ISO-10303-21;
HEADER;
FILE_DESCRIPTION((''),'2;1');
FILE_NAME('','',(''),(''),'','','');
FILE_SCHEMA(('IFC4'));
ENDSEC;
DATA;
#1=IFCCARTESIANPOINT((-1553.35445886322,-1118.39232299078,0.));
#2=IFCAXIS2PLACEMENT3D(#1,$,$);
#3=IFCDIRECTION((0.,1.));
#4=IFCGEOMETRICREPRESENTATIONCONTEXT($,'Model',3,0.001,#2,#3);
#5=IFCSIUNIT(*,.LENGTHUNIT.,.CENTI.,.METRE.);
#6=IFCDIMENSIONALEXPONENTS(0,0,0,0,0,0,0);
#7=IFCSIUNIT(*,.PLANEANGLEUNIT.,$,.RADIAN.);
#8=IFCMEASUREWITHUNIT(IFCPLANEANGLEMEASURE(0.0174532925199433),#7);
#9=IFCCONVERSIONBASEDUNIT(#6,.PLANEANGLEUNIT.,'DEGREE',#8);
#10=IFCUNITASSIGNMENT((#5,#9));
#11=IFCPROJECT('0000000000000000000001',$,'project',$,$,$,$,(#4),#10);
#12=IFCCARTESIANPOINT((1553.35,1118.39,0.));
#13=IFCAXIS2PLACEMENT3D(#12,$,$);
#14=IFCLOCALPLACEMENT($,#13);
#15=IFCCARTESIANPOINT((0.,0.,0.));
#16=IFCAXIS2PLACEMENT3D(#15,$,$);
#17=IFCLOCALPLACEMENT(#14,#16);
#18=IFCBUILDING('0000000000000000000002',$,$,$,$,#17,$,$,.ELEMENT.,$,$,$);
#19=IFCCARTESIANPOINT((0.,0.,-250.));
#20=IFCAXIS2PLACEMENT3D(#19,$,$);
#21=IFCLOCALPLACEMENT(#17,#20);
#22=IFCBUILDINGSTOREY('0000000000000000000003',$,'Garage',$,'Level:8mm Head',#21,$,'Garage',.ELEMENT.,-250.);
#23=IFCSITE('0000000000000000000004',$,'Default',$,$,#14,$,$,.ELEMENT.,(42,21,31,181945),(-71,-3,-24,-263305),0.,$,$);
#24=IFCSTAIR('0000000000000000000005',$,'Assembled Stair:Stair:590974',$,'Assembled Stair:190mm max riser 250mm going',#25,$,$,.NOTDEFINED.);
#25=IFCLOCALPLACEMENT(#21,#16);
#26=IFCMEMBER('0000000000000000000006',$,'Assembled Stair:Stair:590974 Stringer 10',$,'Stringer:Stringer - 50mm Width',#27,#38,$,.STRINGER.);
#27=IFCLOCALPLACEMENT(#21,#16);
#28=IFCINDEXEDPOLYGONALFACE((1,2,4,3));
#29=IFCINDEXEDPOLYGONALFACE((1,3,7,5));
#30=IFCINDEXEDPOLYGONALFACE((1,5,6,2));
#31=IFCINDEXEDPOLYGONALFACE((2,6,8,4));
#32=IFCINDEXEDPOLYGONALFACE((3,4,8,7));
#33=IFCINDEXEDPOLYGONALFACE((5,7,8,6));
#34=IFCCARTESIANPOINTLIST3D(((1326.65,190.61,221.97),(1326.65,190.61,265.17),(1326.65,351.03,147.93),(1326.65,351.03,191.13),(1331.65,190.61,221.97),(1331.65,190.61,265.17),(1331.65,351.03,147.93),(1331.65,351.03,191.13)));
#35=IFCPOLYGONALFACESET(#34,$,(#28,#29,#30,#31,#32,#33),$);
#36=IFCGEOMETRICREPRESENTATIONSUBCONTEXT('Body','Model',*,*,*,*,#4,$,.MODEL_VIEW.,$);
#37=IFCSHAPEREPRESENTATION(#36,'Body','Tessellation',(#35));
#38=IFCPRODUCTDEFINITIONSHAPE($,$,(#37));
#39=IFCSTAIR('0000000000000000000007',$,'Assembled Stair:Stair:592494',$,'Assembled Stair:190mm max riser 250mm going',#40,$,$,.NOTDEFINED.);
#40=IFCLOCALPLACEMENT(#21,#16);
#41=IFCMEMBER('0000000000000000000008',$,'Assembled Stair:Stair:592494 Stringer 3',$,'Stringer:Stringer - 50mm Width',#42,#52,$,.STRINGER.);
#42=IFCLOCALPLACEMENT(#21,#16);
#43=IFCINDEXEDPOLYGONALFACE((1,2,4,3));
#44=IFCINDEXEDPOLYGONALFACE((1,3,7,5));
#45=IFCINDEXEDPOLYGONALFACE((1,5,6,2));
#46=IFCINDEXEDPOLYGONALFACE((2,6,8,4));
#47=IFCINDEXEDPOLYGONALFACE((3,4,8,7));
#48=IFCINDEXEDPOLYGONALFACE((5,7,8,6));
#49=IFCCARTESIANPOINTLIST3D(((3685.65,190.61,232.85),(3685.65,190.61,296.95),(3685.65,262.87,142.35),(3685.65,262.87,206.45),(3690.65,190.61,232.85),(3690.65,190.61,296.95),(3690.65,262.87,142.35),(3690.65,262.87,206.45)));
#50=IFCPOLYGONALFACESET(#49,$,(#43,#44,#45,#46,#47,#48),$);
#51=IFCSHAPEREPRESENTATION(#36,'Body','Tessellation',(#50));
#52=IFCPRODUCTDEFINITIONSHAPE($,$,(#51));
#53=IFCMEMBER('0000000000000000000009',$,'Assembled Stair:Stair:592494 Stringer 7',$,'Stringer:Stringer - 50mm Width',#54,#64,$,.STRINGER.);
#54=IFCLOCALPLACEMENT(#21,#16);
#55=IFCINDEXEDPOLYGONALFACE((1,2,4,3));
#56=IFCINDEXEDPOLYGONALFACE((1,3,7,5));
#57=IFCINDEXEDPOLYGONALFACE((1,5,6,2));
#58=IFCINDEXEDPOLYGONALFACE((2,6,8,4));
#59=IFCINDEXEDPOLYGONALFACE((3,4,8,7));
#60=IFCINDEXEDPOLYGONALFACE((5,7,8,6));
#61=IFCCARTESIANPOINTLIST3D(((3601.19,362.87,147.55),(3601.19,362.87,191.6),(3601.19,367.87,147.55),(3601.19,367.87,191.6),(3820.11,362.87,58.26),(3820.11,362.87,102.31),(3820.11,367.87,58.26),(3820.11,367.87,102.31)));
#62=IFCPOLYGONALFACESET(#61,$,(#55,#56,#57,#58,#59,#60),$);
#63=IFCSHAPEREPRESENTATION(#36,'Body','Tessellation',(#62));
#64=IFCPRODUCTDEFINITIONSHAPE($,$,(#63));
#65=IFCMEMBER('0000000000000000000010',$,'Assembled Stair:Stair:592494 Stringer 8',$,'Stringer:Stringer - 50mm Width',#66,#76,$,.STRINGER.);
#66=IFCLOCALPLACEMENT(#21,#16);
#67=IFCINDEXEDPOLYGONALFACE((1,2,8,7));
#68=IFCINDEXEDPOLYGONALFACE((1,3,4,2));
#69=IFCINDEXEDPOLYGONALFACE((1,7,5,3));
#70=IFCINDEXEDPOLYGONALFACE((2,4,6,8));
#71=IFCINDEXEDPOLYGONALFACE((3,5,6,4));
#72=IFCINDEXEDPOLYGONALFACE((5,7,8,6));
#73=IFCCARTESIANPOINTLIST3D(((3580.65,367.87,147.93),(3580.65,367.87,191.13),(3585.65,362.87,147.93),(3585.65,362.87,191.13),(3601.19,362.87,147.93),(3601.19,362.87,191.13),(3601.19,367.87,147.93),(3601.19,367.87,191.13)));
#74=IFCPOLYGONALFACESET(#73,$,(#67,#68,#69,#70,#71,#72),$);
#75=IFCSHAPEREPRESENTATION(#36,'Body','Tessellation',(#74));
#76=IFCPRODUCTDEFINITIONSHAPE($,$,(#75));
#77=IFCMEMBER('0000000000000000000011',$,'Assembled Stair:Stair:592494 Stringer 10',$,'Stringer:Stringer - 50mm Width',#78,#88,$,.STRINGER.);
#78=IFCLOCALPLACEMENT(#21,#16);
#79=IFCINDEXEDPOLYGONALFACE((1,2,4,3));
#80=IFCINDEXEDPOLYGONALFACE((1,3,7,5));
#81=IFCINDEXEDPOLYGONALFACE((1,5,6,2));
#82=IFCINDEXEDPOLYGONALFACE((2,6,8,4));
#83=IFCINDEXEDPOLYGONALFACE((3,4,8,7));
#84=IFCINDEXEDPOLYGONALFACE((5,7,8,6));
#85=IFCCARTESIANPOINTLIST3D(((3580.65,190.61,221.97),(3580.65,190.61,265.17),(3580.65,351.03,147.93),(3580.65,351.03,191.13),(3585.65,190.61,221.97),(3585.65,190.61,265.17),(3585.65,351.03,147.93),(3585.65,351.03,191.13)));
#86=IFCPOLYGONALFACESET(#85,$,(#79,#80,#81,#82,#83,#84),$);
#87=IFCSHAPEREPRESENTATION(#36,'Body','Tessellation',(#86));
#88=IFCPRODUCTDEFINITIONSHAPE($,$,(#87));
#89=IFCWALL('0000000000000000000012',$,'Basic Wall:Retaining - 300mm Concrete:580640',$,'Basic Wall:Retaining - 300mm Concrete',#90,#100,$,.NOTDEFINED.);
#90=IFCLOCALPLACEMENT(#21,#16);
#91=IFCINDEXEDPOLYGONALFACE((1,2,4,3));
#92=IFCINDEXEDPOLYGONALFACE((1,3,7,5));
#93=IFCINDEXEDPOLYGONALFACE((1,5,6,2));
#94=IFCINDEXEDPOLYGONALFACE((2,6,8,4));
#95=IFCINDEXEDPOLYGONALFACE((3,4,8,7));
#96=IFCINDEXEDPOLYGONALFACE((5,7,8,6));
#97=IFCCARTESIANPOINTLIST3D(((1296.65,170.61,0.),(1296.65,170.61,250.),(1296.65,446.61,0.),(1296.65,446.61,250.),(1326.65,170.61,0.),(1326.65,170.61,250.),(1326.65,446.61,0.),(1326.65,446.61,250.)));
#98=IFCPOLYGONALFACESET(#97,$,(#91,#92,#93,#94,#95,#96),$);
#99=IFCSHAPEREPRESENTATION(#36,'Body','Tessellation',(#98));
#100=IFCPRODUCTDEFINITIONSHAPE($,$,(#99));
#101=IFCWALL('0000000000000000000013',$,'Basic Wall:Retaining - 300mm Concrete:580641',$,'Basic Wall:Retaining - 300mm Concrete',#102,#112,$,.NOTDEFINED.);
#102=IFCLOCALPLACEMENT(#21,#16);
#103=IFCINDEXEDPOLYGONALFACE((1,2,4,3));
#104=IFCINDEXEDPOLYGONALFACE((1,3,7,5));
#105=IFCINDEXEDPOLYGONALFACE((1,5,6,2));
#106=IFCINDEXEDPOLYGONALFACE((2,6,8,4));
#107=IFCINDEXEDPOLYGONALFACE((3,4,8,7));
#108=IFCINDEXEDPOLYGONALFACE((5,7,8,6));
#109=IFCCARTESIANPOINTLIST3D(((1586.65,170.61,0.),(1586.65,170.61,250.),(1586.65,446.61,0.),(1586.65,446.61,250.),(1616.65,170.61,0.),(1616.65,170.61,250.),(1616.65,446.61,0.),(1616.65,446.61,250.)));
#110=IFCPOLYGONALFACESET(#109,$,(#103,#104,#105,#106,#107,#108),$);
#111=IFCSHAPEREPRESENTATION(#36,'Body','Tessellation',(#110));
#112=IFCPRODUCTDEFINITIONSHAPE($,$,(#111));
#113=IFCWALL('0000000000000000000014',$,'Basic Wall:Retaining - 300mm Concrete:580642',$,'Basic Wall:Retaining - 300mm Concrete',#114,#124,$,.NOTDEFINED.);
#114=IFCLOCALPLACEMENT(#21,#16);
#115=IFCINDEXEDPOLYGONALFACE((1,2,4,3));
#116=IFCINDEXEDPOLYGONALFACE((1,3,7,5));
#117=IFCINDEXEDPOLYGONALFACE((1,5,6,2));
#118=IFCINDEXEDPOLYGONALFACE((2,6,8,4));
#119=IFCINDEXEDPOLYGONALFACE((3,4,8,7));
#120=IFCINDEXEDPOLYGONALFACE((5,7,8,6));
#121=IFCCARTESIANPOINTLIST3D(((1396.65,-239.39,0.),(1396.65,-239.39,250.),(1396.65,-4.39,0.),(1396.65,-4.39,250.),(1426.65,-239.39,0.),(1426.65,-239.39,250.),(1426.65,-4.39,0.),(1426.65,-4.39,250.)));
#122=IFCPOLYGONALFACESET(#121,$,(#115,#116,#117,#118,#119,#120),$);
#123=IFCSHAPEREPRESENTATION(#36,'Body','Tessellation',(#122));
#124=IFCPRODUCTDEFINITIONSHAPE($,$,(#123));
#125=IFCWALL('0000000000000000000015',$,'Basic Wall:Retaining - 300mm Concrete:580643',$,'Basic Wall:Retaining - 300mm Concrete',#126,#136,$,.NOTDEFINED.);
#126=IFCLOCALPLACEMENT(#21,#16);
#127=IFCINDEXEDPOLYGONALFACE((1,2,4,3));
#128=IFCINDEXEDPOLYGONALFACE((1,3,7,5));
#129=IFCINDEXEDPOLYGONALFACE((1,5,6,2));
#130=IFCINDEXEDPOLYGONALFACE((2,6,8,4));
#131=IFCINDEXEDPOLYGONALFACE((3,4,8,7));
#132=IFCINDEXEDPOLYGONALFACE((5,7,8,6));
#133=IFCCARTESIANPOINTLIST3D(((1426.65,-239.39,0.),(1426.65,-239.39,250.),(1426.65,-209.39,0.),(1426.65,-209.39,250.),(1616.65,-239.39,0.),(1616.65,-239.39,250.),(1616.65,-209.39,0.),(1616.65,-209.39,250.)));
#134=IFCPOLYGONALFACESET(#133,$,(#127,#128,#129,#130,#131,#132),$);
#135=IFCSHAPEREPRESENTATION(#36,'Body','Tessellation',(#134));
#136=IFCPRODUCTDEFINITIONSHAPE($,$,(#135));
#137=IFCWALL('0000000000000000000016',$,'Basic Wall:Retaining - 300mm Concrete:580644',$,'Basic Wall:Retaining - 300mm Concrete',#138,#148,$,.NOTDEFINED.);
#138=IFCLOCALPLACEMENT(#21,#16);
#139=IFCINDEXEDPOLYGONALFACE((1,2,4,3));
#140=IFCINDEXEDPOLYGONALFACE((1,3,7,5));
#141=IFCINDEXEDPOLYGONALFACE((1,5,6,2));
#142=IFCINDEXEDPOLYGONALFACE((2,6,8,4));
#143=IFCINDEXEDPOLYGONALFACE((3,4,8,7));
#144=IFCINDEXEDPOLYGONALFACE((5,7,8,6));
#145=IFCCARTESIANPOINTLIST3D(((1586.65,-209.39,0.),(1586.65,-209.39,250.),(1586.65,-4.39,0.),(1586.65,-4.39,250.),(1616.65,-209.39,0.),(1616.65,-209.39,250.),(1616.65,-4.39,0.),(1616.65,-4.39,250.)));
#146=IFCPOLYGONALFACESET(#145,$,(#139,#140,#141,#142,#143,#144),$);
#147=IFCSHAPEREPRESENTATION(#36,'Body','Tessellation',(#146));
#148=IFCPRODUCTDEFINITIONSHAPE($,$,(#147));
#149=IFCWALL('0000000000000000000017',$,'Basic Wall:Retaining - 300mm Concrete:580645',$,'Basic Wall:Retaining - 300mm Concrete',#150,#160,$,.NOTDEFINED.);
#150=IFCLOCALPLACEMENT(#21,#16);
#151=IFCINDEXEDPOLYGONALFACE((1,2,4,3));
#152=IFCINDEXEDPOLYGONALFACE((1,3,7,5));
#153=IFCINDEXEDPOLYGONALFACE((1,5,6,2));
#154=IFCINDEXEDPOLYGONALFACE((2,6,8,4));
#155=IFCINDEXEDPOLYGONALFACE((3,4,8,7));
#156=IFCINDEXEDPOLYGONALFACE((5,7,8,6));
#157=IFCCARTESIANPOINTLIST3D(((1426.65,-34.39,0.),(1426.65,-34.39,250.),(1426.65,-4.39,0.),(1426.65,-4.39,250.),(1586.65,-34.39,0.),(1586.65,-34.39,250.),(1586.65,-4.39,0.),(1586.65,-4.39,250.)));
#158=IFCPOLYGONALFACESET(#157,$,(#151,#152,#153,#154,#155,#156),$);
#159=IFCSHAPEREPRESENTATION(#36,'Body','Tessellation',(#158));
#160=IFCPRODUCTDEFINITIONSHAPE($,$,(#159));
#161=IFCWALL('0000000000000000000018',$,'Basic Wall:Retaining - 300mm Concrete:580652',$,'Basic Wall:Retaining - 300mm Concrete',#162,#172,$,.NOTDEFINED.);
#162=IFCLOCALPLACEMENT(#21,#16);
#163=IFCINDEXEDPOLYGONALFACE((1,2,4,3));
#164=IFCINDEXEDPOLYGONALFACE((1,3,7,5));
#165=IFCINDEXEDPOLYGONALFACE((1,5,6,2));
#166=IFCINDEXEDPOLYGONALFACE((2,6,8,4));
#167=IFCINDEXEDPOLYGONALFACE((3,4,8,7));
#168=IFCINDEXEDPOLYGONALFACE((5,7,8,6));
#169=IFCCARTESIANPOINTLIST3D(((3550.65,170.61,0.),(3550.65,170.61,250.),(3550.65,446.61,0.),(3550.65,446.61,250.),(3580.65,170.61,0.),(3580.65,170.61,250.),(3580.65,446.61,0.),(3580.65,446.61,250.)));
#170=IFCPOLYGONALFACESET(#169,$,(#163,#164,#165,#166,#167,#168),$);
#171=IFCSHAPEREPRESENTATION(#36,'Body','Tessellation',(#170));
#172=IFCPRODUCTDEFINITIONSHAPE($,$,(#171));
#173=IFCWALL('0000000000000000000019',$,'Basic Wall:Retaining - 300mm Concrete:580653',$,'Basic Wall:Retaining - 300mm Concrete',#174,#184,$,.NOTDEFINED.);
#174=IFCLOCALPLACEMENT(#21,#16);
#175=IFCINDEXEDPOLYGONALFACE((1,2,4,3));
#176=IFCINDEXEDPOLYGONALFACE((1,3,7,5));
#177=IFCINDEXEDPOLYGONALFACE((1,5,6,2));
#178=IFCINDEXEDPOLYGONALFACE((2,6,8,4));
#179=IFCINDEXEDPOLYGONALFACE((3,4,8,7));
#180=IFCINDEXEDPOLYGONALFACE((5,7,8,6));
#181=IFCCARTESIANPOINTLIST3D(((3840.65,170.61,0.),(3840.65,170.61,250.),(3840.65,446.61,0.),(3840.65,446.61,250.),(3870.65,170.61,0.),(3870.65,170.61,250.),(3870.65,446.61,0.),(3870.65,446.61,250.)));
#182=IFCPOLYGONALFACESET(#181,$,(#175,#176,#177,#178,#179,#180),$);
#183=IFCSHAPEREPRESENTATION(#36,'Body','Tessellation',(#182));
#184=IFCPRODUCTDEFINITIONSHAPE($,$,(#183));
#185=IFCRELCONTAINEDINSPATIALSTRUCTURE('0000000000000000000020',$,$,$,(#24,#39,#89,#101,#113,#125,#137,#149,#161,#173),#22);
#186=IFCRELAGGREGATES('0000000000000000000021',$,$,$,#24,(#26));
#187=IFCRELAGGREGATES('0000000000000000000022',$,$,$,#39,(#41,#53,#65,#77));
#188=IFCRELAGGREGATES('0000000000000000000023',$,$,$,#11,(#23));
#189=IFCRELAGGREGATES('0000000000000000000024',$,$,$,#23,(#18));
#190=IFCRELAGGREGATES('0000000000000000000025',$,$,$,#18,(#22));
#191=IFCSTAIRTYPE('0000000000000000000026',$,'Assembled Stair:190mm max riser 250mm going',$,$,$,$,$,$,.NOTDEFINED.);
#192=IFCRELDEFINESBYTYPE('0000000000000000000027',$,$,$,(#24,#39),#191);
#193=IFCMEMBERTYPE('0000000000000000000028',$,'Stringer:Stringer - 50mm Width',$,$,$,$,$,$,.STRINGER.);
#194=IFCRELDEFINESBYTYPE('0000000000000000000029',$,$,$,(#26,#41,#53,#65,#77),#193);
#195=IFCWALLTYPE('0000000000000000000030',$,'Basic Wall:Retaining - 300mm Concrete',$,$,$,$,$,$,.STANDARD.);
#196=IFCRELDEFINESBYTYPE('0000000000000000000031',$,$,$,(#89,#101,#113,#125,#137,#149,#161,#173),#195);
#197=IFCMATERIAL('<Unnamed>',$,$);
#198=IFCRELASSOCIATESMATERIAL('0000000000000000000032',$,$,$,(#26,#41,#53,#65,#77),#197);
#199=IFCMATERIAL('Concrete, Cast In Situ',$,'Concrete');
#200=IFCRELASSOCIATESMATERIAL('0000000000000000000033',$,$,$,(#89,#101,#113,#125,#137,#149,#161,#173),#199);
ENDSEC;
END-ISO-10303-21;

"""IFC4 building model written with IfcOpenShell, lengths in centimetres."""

from ifc_helpers import new_model, entity, si_unit, converted_unit, direction, frame, origin, place, context, subcontext, project, spatial, indexed_curve, outline, extrude, material, type_object, element, aggregate, save


model = new_model("IFC4")

# Units and contexts
model_context = context("Model", 3, precision=0.001, world=frame((-1553.35445886322, -1118.39232299078, 0.0)), true_north=direction((0.0, 1.0)))
body_context = subcontext(model_context, "Body", "Model", "MODEL_VIEW")
ifc_project = project(units=[si_unit("LENGTHUNIT", "METRE", prefix="CENTI"), converted_unit("PLANEANGLEUNIT", "DEGREE", entity("IfcPlaneAngleMeasure", 0.0174532925199433), si_unit("PLANEANGLEUNIT", "RADIAN"), dimensions=[0, 0, 0, 0, 0, 0, 0])], contexts=[model_context])

# Site, building, storey
site_placement = place(None, frame((1553.35, 1118.39, 0.0)))
site = spatial("IfcSite", under=ifc_project, at=site_placement, Name="Default", CompositionType="ELEMENT", RefLatitude=(42, 21, 31, 181945), RefLongitude=(-71, -3, -24, -263305), RefElevation=0.0)
building_placement = place(site_placement, origin())
building = spatial("IfcBuilding", under=site, at=building_placement, CompositionType="ELEMENT")
storey_placement = place(building_placement, frame((0.0, 0.0, -250.0)))
storey = spatial("IfcBuildingStorey", under=building, at=storey_placement, Name="Garage", ObjectType="Level:8mm Head", LongName="Garage", CompositionType="ELEMENT", Elevation=-250.0)

# Stairs, members
stair_type = type_object("IfcStairType", Name="Assembled Stair:190mm max riser 250mm going", PredefinedType="NOTDEFINED")
stair_1_placement = place(storey_placement, origin())
stair_1 = element("IfcStair", 1, at=stair_1_placement, inside=storey, type_object=stair_type, Name="Assembled Stair:Stair:590974", ObjectType="Assembled Stair:190mm max riser 250mm going", PredefinedType="NOTDEFINED")
ifc_material_1 = material(Name="<Unnamed>")
member_type = type_object("IfcMemberType", Name="Stringer:Stringer - 50mm Width", PredefinedType="STRINGER")
member_1_placement = place(stair_1_placement, origin())
member_1 = element("IfcMember", 2, at=member_1_placement, type_object=member_type, material=ifc_material_1, Name="Assembled Stair:Stair:590974 Stringer 10", ObjectType="Stringer:Stringer - 50mm Width", PredefinedType="STRINGER", context=body_context, shape_type="SweptSolid", body=[
    extrude(outline(indexed_curve([(-79.29, -19.61), (97.39, -19.61), (79.29, 19.61), (-97.39, 19.61), (-79.29, -19.61)], self_intersect=False)), frame((1326.65, 270.82, 206.55), z_axis=(1.0, 0.0, 0.0), x_axis=(0.0, -0.907966, 0.419043)), (0.0, 0.0, 1.0), 5.0),
])
aggregate(stair_1, [member_1])
stair_2_placement = place(storey_placement, origin())
stair_2 = element("IfcStair", 3, at=stair_2_placement, inside=storey, type_object=stair_type, Name="Assembled Stair:Stair:592494", ObjectType="Assembled Stair:190mm max riser 250mm going", PredefinedType="NOTDEFINED")
member_2_placement = place(stair_2_placement, origin())
member_2 = element("IfcMember", 4, at=member_2_placement, type_object=member_type, material=ifc_material_1, Name="Assembled Stair:Stair:592494 Stringer 3", ObjectType="Stringer:Stringer - 50mm Width", PredefinedType="STRINGER", context=body_context, shape_type="SweptSolid", body=[
    extrude(outline(indexed_curve([(-32.86, -20.0), (82.95, -20.0), (32.86, 20.0), (-82.95, 20.0), (-32.86, -20.0)], self_intersect=False)), frame((3685.65, 226.74, 219.65), z_axis=(1.0, 0.0, 0.0), x_axis=(0.0, -0.623994, 0.781429)), (0.0, 0.0, 1.0), 5.0),
])
member_3_placement = place(stair_2_placement, origin())
member_3 = element("IfcMember", 5, at=member_3_placement, type_object=member_type, material=ifc_material_1, Name="Assembled Stair:Stair:592494 Stringer 7", ObjectType="Stringer:Stringer - 50mm Width", PredefinedType="STRINGER", context=body_context, shape_type="SweptSolid", body=[
    extrude(outline(indexed_curve([(-126.53, -20.4), (109.9, -20.4), (126.53, 20.4), (-109.9, 20.4), (-126.53, -20.4)], self_intersect=False)), frame((3710.65, 362.87, 124.93), z_axis=(0.0, 1.0, 0.0), x_axis=(-0.92595, 0.0, 0.377646)), (0.0, 0.0, 1.0), 5.0),
])
member_4_placement = place(stair_2_placement, origin())
member_4 = element("IfcMember", 6, at=member_4_placement, type_object=member_type, material=ifc_material_1, Name="Assembled Stair:Stair:592494 Stringer 8", ObjectType="Stringer:Stringer - 50mm Width", PredefinedType="STRINGER", context=body_context, shape_type="SweptSolid", body=[
    extrude(outline(indexed_curve([(-9.02, -2.5), (11.52, -2.5), (6.52, 2.5), (-9.02, 2.5), (-9.02, -2.5)], self_intersect=False)), frame((3592.17, 365.37, 147.93), z_axis=(0.0, 0.0, 1.0), x_axis=(-1.0, 0.0, 0.0)), (0.0, 0.0, 1.0), 43.2),
])
member_5_placement = place(stair_2_placement, origin())
member_5 = element("IfcMember", 7, at=member_5_placement, type_object=member_type, material=ifc_material_1, Name="Assembled Stair:Stair:592494 Stringer 10", ObjectType="Stringer:Stringer - 50mm Width", PredefinedType="STRINGER", context=body_context, shape_type="SweptSolid", body=[
    extrude(outline(indexed_curve([(-79.29, -19.61), (97.39, -19.61), (79.29, 19.61), (-97.39, 19.61), (-79.29, -19.61)], self_intersect=False)), frame((3580.65, 270.82, 206.55), z_axis=(1.0, 0.0, 0.0), x_axis=(0.0, -0.907966, 0.419043)), (0.0, 0.0, 1.0), 5.0),
])

# Walls
ifc_material_2 = material(Name="Concrete, Cast In Situ", Category="Concrete")
wall_type_1 = type_object("IfcWallType", Name="Basic Wall:Retaining - 300mm Concrete", PredefinedType="STANDARD")
for number, where, z_axis, x_axis, name in (
    (8, (1311.65, 446.61, 0.0), (0.0, 0.0, 1.0), (0.0, -1.0, 0.0), "Basic Wall:Retaining - 300mm Concrete:580640"),
    (9, (1601.65, 446.61, 0.0), (0.0, 0.0, 1.0), (0.0, -1.0, 0.0), "Basic Wall:Retaining - 300mm Concrete:580641"),
):
    element("IfcWall", number, at=place(storey_placement, frame(where, z_axis=z_axis, x_axis=x_axis)), inside=storey, type_object=wall_type_1, material=ifc_material_2, Name=name, ObjectType="Basic Wall:Retaining - 300mm Concrete", PredefinedType="NOTDEFINED", context=body_context, shape_type="SweptSolid", body=[
        extrude(outline(indexed_curve([(276.0, 15.0), (0.0, 15.0), (0.0, -15.0), (276.0, -15.0), (276.0, 15.0)], self_intersect=False)), origin(), (0.0, 0.0, 1.0), 250.0),
    ])
wall_1_placement = place(storey_placement, frame((1411.65, -4.39, 0.0), z_axis=(0.0, 0.0, 1.0), x_axis=(0.0, -1.0, 0.0)))
element("IfcWall", 10, at=wall_1_placement, inside=storey, type_object=wall_type_1, material=ifc_material_2, Name="Basic Wall:Retaining - 300mm Concrete:580642", ObjectType="Basic Wall:Retaining - 300mm Concrete", PredefinedType="NOTDEFINED", context=body_context, shape_type="SweptSolid", body=[
    extrude(outline(indexed_curve([(235.0, 15.0), (0.0, 15.0), (0.0, -15.0), (235.0, -15.0), (235.0, 15.0)], self_intersect=False)), origin(), (0.0, 0.0, 1.0), 250.0),
])
wall_2_placement = place(storey_placement, frame((1426.65, -224.39, 0.0)))
element("IfcWall", 11, at=wall_2_placement, inside=storey, type_object=wall_type_1, material=ifc_material_2, Name="Basic Wall:Retaining - 300mm Concrete:580643", ObjectType="Basic Wall:Retaining - 300mm Concrete", PredefinedType="NOTDEFINED", context=body_context, shape_type="SweptSolid", body=[
    extrude(outline(indexed_curve([(190.0, 15.0), (0.0, 15.0), (0.0, -15.0), (190.0, -15.0), (190.0, 15.0)], self_intersect=False)), origin(), (0.0, 0.0, 1.0), 250.0),
])
wall_3_placement = place(storey_placement, frame((1601.65, -209.39, 0.0), z_axis=(0.0, 0.0, 1.0), x_axis=(0.0, 1.0, 0.0)))
element("IfcWall", 12, at=wall_3_placement, inside=storey, type_object=wall_type_1, material=ifc_material_2, Name="Basic Wall:Retaining - 300mm Concrete:580644", ObjectType="Basic Wall:Retaining - 300mm Concrete", PredefinedType="NOTDEFINED", context=body_context, shape_type="SweptSolid", body=[
    extrude(outline(indexed_curve([(205.0, 15.0), (0.0, 15.0), (0.0, -15.0), (205.0, -15.0), (205.0, 15.0)], self_intersect=False)), origin(), (0.0, 0.0, 1.0), 250.0),
])
wall_4_placement = place(storey_placement, frame((1586.65, -19.39, 0.0), z_axis=(0.0, 0.0, 1.0), x_axis=(-1.0, 0.0, 0.0)))
element("IfcWall", 13, at=wall_4_placement, inside=storey, type_object=wall_type_1, material=ifc_material_2, Name="Basic Wall:Retaining - 300mm Concrete:580645", ObjectType="Basic Wall:Retaining - 300mm Concrete", PredefinedType="NOTDEFINED", context=body_context, shape_type="SweptSolid", body=[
    extrude(outline(indexed_curve([(160.0, 15.0), (0.0, 15.0), (0.0, -15.0), (160.0, -15.0), (160.0, 15.0)], self_intersect=False)), origin(), (0.0, 0.0, 1.0), 250.0),
])
wall_5_placement = place(storey_placement, frame((3565.65, 446.61, 0.0), z_axis=(0.0, 0.0, 1.0), x_axis=(0.0, -1.0, 0.0)))
element("IfcWall", 14, at=wall_5_placement, inside=storey, type_object=wall_type_1, material=ifc_material_2, Name="Basic Wall:Retaining - 300mm Concrete:580652", ObjectType="Basic Wall:Retaining - 300mm Concrete", PredefinedType="NOTDEFINED", context=body_context, shape_type="SweptSolid", body=[
    extrude(outline(indexed_curve([(276.0, 15.0), (0.0, 15.0), (0.0, -15.0), (276.0, -15.0), (276.0, 15.0)], self_intersect=False)), origin(), (0.0, 0.0, 1.0), 250.0),
])
wall_6_placement = place(storey_placement, frame((3855.65, 446.61, 0.0), z_axis=(0.0, 0.0, 1.0), x_axis=(0.0, -1.0, 0.0)))
element("IfcWall", 15, at=wall_6_placement, inside=storey, type_object=wall_type_1, material=ifc_material_2, Name="Basic Wall:Retaining - 300mm Concrete:580653", ObjectType="Basic Wall:Retaining - 300mm Concrete", PredefinedType="NOTDEFINED", context=body_context, shape_type="SweptSolid", body=[
    extrude(outline(indexed_curve([(276.0, 15.0), (0.0, 15.0), (0.0, -15.0), (276.0, -15.0), (276.0, 15.0)], self_intersect=False)), origin(), (0.0, 0.0, 1.0), 250.0),
])

aggregate(stair_2, [member_2, member_3, member_4, member_5])

save(model, "model.ifc")
